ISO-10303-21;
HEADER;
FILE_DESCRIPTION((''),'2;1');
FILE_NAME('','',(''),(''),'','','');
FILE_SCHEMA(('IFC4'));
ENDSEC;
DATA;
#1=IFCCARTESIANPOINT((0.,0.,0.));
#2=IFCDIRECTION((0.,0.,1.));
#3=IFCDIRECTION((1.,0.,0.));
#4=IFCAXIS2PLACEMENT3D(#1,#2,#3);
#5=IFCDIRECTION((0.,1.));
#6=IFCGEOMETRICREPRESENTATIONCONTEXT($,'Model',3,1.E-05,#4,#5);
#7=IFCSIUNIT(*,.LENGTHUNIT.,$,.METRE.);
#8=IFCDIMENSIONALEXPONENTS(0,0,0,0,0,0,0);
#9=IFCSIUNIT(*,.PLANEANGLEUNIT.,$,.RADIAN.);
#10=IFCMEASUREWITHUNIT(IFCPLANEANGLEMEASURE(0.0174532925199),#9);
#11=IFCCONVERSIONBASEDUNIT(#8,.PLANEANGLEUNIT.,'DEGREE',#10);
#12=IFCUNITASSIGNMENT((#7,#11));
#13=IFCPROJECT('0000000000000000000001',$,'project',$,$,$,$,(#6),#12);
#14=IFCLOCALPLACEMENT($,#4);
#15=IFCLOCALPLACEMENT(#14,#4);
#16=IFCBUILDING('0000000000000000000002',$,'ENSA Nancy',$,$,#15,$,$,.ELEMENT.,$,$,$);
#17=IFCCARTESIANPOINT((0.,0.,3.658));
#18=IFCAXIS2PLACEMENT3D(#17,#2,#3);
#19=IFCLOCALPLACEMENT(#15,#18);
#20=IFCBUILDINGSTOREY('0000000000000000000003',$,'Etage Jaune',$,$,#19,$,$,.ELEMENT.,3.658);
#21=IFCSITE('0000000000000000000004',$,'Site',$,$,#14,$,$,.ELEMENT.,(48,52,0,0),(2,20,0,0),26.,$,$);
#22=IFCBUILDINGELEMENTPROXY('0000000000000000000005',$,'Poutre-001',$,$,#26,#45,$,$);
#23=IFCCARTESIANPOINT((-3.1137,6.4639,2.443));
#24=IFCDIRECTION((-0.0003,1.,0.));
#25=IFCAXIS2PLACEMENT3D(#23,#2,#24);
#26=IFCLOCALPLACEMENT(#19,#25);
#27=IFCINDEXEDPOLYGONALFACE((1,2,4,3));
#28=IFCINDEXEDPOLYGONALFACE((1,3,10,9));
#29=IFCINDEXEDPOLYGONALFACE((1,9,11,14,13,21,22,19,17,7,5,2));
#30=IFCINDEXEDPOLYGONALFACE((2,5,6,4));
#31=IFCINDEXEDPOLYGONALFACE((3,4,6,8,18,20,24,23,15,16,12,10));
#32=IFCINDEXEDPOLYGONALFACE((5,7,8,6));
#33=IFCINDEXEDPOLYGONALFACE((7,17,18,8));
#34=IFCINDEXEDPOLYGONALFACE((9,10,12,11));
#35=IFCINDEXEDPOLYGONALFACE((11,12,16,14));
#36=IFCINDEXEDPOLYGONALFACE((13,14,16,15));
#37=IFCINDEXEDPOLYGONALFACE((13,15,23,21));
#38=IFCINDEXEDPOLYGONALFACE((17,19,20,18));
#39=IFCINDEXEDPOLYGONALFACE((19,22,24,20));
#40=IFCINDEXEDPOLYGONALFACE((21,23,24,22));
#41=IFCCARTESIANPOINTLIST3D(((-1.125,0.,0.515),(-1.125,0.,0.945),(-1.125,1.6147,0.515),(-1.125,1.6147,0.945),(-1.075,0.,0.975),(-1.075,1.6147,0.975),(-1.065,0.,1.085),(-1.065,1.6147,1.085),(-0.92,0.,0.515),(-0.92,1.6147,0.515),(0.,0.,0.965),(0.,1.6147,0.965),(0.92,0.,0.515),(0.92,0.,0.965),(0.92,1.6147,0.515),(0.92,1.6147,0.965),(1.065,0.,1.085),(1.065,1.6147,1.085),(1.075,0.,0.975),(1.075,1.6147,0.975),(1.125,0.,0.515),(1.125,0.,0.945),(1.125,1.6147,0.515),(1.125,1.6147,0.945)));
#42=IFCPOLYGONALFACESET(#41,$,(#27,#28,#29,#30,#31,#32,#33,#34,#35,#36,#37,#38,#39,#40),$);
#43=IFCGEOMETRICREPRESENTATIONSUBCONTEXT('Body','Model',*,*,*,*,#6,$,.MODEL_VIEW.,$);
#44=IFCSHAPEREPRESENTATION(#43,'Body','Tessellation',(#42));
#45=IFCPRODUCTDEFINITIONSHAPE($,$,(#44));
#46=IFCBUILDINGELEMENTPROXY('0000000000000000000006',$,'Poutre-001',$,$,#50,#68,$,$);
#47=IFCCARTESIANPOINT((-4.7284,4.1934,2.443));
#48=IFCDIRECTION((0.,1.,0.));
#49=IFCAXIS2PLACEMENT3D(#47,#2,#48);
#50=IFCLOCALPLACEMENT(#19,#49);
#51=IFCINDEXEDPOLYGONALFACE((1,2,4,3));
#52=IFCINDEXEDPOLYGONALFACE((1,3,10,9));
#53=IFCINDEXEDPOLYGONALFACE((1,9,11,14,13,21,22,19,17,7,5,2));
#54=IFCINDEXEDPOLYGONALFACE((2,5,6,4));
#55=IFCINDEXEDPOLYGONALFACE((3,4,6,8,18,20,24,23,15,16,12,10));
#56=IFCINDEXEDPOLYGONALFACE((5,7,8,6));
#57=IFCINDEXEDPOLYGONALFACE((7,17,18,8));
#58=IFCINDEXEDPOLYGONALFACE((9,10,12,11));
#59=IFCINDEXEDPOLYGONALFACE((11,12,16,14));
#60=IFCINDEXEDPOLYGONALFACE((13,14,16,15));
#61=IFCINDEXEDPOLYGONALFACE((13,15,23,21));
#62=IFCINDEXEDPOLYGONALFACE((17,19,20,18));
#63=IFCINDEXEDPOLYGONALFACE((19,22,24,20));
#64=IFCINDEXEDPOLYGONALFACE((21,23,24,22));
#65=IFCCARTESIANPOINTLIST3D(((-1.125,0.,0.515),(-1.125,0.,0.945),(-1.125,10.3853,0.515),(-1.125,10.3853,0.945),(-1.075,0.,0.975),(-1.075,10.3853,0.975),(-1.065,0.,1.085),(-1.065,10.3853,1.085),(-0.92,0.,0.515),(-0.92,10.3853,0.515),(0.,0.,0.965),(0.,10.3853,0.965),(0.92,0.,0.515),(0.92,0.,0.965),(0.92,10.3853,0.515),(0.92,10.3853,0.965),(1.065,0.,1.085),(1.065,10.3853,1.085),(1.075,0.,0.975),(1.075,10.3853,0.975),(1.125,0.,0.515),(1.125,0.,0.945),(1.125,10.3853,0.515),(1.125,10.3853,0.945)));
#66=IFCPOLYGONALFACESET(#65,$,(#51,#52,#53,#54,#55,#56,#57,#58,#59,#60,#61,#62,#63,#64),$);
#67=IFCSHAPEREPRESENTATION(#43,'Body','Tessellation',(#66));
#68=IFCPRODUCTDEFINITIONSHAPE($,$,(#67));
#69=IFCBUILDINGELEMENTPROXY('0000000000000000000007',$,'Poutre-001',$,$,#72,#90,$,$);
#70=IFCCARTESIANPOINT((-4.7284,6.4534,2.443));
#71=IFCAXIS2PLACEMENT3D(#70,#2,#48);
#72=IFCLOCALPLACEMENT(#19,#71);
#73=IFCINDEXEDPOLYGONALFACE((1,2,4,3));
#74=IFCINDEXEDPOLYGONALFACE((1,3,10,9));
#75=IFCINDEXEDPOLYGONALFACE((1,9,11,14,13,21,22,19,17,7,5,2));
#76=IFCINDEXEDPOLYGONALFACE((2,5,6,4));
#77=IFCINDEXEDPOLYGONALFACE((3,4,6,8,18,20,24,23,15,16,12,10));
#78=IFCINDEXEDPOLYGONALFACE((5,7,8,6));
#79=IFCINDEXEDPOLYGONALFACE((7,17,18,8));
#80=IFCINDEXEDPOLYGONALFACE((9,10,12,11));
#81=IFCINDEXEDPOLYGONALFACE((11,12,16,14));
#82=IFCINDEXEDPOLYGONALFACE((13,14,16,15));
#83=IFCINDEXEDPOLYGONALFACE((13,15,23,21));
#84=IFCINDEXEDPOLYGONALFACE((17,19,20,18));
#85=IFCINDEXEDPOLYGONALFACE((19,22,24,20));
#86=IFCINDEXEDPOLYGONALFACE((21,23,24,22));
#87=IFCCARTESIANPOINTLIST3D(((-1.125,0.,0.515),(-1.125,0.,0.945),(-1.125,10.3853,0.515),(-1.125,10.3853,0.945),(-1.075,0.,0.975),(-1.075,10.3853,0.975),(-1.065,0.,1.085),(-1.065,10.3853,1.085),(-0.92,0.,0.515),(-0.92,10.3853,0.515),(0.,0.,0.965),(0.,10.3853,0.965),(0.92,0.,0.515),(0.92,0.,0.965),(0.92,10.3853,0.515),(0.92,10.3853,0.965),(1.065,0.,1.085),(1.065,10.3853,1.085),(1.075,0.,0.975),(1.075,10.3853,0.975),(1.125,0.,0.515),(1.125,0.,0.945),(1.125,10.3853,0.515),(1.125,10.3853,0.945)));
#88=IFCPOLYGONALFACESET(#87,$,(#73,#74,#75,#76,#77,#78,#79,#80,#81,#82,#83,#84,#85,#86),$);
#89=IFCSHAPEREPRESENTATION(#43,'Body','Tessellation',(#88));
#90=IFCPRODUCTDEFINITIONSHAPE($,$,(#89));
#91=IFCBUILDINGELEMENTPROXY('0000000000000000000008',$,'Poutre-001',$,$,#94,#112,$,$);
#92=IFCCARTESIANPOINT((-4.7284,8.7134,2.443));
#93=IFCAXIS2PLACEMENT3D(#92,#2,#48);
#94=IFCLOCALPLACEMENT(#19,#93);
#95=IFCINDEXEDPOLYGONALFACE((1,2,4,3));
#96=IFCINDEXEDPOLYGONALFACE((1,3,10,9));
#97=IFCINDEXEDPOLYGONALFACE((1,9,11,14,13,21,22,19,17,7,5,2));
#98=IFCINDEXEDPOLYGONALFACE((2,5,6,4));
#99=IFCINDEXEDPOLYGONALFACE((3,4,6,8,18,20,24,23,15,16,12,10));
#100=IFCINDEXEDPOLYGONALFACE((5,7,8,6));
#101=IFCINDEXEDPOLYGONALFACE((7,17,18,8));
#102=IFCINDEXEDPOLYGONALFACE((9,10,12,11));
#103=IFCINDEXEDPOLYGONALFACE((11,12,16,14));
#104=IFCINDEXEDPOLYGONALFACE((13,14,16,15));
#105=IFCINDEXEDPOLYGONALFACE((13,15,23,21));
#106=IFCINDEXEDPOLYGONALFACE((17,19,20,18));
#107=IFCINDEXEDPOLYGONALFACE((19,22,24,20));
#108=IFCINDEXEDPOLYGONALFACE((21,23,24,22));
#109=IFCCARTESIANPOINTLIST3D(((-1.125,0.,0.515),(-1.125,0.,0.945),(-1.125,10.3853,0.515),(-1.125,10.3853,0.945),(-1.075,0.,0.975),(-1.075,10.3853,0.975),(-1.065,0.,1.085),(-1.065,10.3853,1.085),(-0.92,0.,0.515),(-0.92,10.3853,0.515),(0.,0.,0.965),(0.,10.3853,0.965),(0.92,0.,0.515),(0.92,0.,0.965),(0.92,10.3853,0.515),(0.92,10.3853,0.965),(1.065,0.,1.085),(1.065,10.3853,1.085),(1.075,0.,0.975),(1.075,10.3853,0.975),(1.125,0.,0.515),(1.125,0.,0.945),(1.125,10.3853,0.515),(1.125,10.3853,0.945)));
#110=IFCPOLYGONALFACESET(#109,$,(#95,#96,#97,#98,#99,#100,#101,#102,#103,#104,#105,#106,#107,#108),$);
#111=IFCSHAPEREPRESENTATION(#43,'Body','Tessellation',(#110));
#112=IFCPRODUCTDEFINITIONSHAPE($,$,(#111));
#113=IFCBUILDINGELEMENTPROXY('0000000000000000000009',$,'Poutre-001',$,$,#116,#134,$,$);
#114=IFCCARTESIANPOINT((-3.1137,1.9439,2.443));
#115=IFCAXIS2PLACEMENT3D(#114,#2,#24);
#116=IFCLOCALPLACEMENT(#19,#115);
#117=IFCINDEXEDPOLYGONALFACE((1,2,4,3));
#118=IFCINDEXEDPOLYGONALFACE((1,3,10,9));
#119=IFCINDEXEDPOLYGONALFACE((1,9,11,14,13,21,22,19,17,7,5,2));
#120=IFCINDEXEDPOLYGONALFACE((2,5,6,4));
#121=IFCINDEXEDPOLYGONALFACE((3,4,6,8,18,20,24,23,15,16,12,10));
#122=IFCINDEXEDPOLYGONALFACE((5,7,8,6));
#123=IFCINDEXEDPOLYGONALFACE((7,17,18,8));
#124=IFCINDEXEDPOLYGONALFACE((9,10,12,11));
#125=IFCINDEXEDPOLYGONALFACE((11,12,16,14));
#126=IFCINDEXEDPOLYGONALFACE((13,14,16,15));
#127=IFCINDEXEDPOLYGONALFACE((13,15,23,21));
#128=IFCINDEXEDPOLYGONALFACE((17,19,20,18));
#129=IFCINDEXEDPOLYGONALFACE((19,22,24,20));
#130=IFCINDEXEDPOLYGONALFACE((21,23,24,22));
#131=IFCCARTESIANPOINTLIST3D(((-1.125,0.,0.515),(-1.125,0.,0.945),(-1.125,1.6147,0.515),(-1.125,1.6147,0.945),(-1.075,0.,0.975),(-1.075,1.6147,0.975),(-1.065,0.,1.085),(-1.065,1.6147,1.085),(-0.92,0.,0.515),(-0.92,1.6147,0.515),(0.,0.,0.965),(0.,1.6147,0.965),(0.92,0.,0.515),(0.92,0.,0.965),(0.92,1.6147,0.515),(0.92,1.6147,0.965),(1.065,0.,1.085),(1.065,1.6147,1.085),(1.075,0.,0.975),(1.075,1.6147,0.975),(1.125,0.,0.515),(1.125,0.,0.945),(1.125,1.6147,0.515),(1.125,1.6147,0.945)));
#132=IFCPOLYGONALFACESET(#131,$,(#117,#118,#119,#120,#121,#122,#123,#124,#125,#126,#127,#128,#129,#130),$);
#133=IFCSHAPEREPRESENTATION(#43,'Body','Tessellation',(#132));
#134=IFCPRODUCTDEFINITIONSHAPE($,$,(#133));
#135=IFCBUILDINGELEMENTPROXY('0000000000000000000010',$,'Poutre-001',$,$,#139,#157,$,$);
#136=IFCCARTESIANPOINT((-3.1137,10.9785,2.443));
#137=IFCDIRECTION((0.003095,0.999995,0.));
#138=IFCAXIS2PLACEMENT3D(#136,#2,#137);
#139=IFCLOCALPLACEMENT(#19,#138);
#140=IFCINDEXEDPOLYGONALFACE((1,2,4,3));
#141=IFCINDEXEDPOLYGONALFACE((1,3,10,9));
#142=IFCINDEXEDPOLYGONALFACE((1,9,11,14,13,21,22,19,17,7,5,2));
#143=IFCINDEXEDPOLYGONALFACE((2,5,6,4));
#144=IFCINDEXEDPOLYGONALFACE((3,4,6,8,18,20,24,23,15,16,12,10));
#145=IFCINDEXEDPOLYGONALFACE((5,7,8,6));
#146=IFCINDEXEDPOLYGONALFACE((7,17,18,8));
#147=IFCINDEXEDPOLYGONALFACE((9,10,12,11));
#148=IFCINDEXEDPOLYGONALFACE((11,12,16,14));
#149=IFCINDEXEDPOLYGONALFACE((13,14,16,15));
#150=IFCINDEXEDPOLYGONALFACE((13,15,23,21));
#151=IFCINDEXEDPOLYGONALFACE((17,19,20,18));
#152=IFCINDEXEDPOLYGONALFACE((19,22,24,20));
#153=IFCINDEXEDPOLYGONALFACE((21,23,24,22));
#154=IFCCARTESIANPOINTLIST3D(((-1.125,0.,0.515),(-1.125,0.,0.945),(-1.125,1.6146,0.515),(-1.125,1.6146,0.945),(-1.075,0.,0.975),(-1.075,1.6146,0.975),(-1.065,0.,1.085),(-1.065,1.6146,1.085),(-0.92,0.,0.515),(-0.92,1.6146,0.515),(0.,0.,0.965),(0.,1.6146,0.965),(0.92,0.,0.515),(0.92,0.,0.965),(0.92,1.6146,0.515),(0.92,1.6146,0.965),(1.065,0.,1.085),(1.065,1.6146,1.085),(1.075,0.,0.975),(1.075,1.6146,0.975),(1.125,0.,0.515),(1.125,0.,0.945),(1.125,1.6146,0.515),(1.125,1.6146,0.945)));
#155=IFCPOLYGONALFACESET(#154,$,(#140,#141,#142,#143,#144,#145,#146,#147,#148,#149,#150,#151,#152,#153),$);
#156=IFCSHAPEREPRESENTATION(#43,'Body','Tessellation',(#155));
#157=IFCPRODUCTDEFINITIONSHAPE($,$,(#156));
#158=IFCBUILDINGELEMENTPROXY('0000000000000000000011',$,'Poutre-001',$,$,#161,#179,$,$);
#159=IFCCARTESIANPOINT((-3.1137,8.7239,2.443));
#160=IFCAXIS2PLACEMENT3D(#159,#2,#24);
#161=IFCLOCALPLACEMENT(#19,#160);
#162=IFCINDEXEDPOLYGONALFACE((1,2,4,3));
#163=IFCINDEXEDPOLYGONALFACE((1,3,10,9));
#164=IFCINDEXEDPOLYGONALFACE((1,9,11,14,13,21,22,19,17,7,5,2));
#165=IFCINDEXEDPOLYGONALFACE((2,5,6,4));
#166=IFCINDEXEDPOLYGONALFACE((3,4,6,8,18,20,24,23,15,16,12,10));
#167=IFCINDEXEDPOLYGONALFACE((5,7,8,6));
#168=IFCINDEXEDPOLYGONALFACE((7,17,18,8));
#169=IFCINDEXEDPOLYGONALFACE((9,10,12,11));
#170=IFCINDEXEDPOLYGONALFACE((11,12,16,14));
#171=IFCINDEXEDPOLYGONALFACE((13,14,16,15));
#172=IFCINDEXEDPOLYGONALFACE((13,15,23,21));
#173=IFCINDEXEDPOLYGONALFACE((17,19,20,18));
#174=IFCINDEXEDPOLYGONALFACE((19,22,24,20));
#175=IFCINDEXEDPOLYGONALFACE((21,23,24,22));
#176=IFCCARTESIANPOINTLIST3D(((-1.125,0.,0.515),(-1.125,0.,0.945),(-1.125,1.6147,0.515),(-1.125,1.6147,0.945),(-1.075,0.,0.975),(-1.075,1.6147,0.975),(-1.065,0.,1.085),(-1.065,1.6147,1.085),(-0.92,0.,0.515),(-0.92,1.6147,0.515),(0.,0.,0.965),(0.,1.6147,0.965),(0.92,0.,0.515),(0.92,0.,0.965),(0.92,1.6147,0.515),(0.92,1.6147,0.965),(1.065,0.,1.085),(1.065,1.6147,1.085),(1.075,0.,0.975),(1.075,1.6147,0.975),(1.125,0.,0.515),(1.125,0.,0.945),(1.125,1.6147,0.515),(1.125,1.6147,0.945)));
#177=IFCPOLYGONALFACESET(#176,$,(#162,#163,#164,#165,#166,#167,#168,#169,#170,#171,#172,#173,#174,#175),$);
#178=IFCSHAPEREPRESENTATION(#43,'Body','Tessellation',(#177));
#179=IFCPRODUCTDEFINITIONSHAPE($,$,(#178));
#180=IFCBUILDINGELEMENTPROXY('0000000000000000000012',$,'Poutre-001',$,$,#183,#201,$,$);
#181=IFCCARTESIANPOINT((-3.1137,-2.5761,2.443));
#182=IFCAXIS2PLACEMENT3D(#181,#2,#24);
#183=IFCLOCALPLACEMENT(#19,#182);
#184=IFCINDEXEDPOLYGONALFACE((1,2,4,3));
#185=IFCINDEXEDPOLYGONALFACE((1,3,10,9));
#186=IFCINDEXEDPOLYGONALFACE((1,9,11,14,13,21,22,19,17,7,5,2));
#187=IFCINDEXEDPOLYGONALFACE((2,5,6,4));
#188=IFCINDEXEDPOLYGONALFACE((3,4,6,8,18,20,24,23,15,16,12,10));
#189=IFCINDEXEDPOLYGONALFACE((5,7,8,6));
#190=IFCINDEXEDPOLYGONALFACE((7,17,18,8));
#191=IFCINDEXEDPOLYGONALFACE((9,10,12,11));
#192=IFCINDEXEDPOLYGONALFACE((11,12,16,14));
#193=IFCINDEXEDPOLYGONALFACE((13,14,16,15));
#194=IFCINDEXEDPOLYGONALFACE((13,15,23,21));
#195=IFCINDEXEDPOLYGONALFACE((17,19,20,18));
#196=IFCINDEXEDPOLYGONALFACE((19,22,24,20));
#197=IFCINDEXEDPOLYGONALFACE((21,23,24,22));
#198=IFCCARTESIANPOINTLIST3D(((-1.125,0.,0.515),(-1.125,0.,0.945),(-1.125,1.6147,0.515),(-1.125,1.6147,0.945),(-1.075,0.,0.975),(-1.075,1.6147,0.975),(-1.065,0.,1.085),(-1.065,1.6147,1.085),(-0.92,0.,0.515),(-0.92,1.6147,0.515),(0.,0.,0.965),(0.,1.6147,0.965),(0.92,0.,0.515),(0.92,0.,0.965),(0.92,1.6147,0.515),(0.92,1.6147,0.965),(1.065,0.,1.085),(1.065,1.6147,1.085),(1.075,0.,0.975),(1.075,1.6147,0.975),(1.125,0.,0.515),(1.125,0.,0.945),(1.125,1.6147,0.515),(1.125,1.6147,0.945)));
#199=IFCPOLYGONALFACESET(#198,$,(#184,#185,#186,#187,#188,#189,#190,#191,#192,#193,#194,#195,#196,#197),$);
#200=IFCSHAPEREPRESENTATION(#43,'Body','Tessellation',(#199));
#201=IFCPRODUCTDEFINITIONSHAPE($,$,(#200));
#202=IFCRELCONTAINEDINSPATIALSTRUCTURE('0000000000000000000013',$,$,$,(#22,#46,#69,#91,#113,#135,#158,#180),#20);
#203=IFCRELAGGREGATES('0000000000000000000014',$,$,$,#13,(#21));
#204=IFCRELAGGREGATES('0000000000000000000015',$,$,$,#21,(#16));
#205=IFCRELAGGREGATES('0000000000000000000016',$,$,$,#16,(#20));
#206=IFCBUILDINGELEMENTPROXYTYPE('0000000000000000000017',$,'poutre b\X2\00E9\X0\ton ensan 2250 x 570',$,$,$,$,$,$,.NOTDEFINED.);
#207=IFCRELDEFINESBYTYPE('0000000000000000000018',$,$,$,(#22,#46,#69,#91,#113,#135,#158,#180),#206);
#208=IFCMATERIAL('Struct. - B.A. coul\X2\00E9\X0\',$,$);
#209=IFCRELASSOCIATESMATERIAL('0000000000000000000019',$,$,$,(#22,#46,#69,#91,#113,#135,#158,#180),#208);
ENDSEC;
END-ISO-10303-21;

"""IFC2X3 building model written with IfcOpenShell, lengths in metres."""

from ifc_helpers import new_model, entity, si_unit, converted_unit, direction, frame, origin_with_axes, place, context, subcontext, project, spatial, polyline, outline, extrude, material, type_object, element, save


model = new_model("IFC2X3")

# Units and contexts
model_context = context("Model", 3, precision=1e-05, world=origin_with_axes(), true_north=direction((0.0, 1.0)))
body_context = subcontext(model_context, "Body", "Model", "MODEL_VIEW")
ifc_project = project(units=[si_unit("LENGTHUNIT", "METRE"), converted_unit("PLANEANGLEUNIT", "DEGREE", entity("IfcPlaneAngleMeasure", 0.0174532925199), si_unit("PLANEANGLEUNIT", "RADIAN"), dimensions=[0, 0, 0, 0, 0, 0, 0])], contexts=[model_context])

# Site, building, storey
site_placement = place(None, origin_with_axes())
site = spatial("IfcSite", under=ifc_project, at=site_placement, Name="Site", CompositionType="ELEMENT", RefLatitude=(48, 52, 0, 0), RefLongitude=(2, 20, 0, 0), RefElevation=26.0)
building_placement = place(site_placement, origin_with_axes())
building = spatial("IfcBuilding", under=site, at=building_placement, Name="ENSA Nancy", CompositionType="ELEMENT")
storey_placement = place(building_placement, frame((0.0, 0.0, 3.658), z_axis=(0.0, 0.0, 1.0), x_axis=(1.0, 0.0, 0.0)))
storey = spatial("IfcBuildingStorey", under=building, at=storey_placement, Name="Etage Jaune", CompositionType="ELEMENT", Elevation=3.658)

# Building element proxies
ifc_material_1 = material(Name="Struct. - B.A. coulé")
building_element_proxy_type_1 = type_object("IfcBuildingElementProxyType", Name="poutre béton ensan 2250 x 570", PredefinedType="NOTDEFINED")
proxy_1_placement = place(storey_placement, frame((-3.1137, 6.4639, 2.443), z_axis=(0.0, 0.0, 1.0), x_axis=(-0.0003, 1.0, 0.0)))
element("IfcBuildingElementProxy", 1, at=proxy_1_placement, inside=storey, type_object=building_element_proxy_type_1, material=ifc_material_1, Name="Poutre-001", context=body_context, shape_type="SweptSolid", body=[
    extrude(outline(polyline([(-1.065, 1.085), (-1.075, 0.975), (-1.125, 0.945), (-1.125, 0.515), (-0.92, 0.515), (0.0, 0.965), (0.92, 0.965), (0.92, 0.515), (1.125, 0.515), (1.125, 0.945), (1.075, 0.975), (1.065, 1.085), (-1.065, 1.085)])), frame((0.0, 1.6147, 0.0), z_axis=(0.0, -1.0, 0.0), x_axis=(1.0, 0.0, 0.0)), (0.0, 0.0, 1.0), 1.6147),
])
for number, where, z_axis, x_axis, name in (
    (2, (-4.7284, 4.1934, 2.443), (0.0, 0.0, 1.0), (0.0, 1.0, 0.0), "Poutre-001"),
    (3, (-4.7284, 6.4534, 2.443), (0.0, 0.0, 1.0), (0.0, 1.0, 0.0), "Poutre-001"),
    (4, (-4.7284, 8.7134, 2.443), (0.0, 0.0, 1.0), (0.0, 1.0, 0.0), "Poutre-001"),
):
    element("IfcBuildingElementProxy", number, at=place(storey_placement, frame(where, z_axis=z_axis, x_axis=x_axis)), inside=storey, type_object=building_element_proxy_type_1, material=ifc_material_1, Name=name, context=body_context, shape_type="SweptSolid", body=[
        extrude(outline(polyline([(-1.065, 1.085), (-1.075, 0.975), (-1.125, 0.945), (-1.125, 0.515), (-0.92, 0.515), (0.0, 0.965), (0.92, 0.965), (0.92, 0.515), (1.125, 0.515), (1.125, 0.945), (1.075, 0.975), (1.065, 1.085), (-1.065, 1.085)])), frame((0.0, 10.3853, 0.0), z_axis=(0.0, -1.0, 0.0), x_axis=(1.0, 0.0, 0.0)), (0.0, 0.0, 1.0), 10.3853),
    ])
proxy_2_placement = place(storey_placement, frame((-3.1137, 1.9439, 2.443), z_axis=(0.0, 0.0, 1.0), x_axis=(-0.0003, 1.0, 0.0)))
element("IfcBuildingElementProxy", 5, at=proxy_2_placement, inside=storey, type_object=building_element_proxy_type_1, material=ifc_material_1, Name="Poutre-001", context=body_context, shape_type="SweptSolid", body=[
    extrude(outline(polyline([(-1.065, 1.085), (-1.075, 0.975), (-1.125, 0.945), (-1.125, 0.515), (-0.92, 0.515), (0.0, 0.965), (0.92, 0.965), (0.92, 0.515), (1.125, 0.515), (1.125, 0.945), (1.075, 0.975), (1.065, 1.085), (-1.065, 1.085)])), frame((0.0, 1.6147, 0.0), z_axis=(0.0, -1.0, 0.0), x_axis=(1.0, 0.0, 0.0)), (0.0, 0.0, 1.0), 1.6147),
])
proxy_3_placement = place(storey_placement, frame((-3.1137, 10.9785, 2.443), z_axis=(0.0, 0.0, 1.0), x_axis=(0.003095, 0.999995, 0.0)))
element("IfcBuildingElementProxy", 6, at=proxy_3_placement, inside=storey, type_object=building_element_proxy_type_1, material=ifc_material_1, Name="Poutre-001", context=body_context, shape_type="SweptSolid", body=[
    extrude(outline(polyline([(-1.065, 1.085), (-1.075, 0.975), (-1.125, 0.945), (-1.125, 0.515), (-0.92, 0.515), (0.0, 0.965), (0.92, 0.965), (0.92, 0.515), (1.125, 0.515), (1.125, 0.945), (1.075, 0.975), (1.065, 1.085), (-1.065, 1.085)])), frame((0.0, 1.6146, 0.0), z_axis=(0.0, -1.0, 0.0), x_axis=(1.0, 0.0, 0.0)), (0.0, 0.0, 1.0), 1.6146),
])
for number, where, z_axis, x_axis, name in (
    (7, (-3.1137, 8.7239, 2.443), (0.0, 0.0, 1.0), (-0.0003, 1.0, 0.0), "Poutre-001"),
    (8, (-3.1137, -2.5761, 2.443), (0.0, 0.0, 1.0), (-0.0003, 1.0, 0.0), "Poutre-001"),
):
    element("IfcBuildingElementProxy", number, at=place(storey_placement, frame(where, z_axis=z_axis, x_axis=x_axis)), inside=storey, type_object=building_element_proxy_type_1, material=ifc_material_1, Name=name, context=body_context, shape_type="SweptSolid", body=[
        extrude(outline(polyline([(-1.065, 1.085), (-1.075, 0.975), (-1.125, 0.945), (-1.125, 0.515), (-0.92, 0.515), (0.0, 0.965), (0.92, 0.965), (0.92, 0.515), (1.125, 0.515), (1.125, 0.945), (1.075, 0.975), (1.065, 1.085), (-1.065, 1.085)])), frame((0.0, 1.6147, 0.0), z_axis=(0.0, -1.0, 0.0), x_axis=(1.0, 0.0, 0.0)), (0.0, 0.0, 1.0), 1.6147),
    ])

save(model, "model.ifc")
